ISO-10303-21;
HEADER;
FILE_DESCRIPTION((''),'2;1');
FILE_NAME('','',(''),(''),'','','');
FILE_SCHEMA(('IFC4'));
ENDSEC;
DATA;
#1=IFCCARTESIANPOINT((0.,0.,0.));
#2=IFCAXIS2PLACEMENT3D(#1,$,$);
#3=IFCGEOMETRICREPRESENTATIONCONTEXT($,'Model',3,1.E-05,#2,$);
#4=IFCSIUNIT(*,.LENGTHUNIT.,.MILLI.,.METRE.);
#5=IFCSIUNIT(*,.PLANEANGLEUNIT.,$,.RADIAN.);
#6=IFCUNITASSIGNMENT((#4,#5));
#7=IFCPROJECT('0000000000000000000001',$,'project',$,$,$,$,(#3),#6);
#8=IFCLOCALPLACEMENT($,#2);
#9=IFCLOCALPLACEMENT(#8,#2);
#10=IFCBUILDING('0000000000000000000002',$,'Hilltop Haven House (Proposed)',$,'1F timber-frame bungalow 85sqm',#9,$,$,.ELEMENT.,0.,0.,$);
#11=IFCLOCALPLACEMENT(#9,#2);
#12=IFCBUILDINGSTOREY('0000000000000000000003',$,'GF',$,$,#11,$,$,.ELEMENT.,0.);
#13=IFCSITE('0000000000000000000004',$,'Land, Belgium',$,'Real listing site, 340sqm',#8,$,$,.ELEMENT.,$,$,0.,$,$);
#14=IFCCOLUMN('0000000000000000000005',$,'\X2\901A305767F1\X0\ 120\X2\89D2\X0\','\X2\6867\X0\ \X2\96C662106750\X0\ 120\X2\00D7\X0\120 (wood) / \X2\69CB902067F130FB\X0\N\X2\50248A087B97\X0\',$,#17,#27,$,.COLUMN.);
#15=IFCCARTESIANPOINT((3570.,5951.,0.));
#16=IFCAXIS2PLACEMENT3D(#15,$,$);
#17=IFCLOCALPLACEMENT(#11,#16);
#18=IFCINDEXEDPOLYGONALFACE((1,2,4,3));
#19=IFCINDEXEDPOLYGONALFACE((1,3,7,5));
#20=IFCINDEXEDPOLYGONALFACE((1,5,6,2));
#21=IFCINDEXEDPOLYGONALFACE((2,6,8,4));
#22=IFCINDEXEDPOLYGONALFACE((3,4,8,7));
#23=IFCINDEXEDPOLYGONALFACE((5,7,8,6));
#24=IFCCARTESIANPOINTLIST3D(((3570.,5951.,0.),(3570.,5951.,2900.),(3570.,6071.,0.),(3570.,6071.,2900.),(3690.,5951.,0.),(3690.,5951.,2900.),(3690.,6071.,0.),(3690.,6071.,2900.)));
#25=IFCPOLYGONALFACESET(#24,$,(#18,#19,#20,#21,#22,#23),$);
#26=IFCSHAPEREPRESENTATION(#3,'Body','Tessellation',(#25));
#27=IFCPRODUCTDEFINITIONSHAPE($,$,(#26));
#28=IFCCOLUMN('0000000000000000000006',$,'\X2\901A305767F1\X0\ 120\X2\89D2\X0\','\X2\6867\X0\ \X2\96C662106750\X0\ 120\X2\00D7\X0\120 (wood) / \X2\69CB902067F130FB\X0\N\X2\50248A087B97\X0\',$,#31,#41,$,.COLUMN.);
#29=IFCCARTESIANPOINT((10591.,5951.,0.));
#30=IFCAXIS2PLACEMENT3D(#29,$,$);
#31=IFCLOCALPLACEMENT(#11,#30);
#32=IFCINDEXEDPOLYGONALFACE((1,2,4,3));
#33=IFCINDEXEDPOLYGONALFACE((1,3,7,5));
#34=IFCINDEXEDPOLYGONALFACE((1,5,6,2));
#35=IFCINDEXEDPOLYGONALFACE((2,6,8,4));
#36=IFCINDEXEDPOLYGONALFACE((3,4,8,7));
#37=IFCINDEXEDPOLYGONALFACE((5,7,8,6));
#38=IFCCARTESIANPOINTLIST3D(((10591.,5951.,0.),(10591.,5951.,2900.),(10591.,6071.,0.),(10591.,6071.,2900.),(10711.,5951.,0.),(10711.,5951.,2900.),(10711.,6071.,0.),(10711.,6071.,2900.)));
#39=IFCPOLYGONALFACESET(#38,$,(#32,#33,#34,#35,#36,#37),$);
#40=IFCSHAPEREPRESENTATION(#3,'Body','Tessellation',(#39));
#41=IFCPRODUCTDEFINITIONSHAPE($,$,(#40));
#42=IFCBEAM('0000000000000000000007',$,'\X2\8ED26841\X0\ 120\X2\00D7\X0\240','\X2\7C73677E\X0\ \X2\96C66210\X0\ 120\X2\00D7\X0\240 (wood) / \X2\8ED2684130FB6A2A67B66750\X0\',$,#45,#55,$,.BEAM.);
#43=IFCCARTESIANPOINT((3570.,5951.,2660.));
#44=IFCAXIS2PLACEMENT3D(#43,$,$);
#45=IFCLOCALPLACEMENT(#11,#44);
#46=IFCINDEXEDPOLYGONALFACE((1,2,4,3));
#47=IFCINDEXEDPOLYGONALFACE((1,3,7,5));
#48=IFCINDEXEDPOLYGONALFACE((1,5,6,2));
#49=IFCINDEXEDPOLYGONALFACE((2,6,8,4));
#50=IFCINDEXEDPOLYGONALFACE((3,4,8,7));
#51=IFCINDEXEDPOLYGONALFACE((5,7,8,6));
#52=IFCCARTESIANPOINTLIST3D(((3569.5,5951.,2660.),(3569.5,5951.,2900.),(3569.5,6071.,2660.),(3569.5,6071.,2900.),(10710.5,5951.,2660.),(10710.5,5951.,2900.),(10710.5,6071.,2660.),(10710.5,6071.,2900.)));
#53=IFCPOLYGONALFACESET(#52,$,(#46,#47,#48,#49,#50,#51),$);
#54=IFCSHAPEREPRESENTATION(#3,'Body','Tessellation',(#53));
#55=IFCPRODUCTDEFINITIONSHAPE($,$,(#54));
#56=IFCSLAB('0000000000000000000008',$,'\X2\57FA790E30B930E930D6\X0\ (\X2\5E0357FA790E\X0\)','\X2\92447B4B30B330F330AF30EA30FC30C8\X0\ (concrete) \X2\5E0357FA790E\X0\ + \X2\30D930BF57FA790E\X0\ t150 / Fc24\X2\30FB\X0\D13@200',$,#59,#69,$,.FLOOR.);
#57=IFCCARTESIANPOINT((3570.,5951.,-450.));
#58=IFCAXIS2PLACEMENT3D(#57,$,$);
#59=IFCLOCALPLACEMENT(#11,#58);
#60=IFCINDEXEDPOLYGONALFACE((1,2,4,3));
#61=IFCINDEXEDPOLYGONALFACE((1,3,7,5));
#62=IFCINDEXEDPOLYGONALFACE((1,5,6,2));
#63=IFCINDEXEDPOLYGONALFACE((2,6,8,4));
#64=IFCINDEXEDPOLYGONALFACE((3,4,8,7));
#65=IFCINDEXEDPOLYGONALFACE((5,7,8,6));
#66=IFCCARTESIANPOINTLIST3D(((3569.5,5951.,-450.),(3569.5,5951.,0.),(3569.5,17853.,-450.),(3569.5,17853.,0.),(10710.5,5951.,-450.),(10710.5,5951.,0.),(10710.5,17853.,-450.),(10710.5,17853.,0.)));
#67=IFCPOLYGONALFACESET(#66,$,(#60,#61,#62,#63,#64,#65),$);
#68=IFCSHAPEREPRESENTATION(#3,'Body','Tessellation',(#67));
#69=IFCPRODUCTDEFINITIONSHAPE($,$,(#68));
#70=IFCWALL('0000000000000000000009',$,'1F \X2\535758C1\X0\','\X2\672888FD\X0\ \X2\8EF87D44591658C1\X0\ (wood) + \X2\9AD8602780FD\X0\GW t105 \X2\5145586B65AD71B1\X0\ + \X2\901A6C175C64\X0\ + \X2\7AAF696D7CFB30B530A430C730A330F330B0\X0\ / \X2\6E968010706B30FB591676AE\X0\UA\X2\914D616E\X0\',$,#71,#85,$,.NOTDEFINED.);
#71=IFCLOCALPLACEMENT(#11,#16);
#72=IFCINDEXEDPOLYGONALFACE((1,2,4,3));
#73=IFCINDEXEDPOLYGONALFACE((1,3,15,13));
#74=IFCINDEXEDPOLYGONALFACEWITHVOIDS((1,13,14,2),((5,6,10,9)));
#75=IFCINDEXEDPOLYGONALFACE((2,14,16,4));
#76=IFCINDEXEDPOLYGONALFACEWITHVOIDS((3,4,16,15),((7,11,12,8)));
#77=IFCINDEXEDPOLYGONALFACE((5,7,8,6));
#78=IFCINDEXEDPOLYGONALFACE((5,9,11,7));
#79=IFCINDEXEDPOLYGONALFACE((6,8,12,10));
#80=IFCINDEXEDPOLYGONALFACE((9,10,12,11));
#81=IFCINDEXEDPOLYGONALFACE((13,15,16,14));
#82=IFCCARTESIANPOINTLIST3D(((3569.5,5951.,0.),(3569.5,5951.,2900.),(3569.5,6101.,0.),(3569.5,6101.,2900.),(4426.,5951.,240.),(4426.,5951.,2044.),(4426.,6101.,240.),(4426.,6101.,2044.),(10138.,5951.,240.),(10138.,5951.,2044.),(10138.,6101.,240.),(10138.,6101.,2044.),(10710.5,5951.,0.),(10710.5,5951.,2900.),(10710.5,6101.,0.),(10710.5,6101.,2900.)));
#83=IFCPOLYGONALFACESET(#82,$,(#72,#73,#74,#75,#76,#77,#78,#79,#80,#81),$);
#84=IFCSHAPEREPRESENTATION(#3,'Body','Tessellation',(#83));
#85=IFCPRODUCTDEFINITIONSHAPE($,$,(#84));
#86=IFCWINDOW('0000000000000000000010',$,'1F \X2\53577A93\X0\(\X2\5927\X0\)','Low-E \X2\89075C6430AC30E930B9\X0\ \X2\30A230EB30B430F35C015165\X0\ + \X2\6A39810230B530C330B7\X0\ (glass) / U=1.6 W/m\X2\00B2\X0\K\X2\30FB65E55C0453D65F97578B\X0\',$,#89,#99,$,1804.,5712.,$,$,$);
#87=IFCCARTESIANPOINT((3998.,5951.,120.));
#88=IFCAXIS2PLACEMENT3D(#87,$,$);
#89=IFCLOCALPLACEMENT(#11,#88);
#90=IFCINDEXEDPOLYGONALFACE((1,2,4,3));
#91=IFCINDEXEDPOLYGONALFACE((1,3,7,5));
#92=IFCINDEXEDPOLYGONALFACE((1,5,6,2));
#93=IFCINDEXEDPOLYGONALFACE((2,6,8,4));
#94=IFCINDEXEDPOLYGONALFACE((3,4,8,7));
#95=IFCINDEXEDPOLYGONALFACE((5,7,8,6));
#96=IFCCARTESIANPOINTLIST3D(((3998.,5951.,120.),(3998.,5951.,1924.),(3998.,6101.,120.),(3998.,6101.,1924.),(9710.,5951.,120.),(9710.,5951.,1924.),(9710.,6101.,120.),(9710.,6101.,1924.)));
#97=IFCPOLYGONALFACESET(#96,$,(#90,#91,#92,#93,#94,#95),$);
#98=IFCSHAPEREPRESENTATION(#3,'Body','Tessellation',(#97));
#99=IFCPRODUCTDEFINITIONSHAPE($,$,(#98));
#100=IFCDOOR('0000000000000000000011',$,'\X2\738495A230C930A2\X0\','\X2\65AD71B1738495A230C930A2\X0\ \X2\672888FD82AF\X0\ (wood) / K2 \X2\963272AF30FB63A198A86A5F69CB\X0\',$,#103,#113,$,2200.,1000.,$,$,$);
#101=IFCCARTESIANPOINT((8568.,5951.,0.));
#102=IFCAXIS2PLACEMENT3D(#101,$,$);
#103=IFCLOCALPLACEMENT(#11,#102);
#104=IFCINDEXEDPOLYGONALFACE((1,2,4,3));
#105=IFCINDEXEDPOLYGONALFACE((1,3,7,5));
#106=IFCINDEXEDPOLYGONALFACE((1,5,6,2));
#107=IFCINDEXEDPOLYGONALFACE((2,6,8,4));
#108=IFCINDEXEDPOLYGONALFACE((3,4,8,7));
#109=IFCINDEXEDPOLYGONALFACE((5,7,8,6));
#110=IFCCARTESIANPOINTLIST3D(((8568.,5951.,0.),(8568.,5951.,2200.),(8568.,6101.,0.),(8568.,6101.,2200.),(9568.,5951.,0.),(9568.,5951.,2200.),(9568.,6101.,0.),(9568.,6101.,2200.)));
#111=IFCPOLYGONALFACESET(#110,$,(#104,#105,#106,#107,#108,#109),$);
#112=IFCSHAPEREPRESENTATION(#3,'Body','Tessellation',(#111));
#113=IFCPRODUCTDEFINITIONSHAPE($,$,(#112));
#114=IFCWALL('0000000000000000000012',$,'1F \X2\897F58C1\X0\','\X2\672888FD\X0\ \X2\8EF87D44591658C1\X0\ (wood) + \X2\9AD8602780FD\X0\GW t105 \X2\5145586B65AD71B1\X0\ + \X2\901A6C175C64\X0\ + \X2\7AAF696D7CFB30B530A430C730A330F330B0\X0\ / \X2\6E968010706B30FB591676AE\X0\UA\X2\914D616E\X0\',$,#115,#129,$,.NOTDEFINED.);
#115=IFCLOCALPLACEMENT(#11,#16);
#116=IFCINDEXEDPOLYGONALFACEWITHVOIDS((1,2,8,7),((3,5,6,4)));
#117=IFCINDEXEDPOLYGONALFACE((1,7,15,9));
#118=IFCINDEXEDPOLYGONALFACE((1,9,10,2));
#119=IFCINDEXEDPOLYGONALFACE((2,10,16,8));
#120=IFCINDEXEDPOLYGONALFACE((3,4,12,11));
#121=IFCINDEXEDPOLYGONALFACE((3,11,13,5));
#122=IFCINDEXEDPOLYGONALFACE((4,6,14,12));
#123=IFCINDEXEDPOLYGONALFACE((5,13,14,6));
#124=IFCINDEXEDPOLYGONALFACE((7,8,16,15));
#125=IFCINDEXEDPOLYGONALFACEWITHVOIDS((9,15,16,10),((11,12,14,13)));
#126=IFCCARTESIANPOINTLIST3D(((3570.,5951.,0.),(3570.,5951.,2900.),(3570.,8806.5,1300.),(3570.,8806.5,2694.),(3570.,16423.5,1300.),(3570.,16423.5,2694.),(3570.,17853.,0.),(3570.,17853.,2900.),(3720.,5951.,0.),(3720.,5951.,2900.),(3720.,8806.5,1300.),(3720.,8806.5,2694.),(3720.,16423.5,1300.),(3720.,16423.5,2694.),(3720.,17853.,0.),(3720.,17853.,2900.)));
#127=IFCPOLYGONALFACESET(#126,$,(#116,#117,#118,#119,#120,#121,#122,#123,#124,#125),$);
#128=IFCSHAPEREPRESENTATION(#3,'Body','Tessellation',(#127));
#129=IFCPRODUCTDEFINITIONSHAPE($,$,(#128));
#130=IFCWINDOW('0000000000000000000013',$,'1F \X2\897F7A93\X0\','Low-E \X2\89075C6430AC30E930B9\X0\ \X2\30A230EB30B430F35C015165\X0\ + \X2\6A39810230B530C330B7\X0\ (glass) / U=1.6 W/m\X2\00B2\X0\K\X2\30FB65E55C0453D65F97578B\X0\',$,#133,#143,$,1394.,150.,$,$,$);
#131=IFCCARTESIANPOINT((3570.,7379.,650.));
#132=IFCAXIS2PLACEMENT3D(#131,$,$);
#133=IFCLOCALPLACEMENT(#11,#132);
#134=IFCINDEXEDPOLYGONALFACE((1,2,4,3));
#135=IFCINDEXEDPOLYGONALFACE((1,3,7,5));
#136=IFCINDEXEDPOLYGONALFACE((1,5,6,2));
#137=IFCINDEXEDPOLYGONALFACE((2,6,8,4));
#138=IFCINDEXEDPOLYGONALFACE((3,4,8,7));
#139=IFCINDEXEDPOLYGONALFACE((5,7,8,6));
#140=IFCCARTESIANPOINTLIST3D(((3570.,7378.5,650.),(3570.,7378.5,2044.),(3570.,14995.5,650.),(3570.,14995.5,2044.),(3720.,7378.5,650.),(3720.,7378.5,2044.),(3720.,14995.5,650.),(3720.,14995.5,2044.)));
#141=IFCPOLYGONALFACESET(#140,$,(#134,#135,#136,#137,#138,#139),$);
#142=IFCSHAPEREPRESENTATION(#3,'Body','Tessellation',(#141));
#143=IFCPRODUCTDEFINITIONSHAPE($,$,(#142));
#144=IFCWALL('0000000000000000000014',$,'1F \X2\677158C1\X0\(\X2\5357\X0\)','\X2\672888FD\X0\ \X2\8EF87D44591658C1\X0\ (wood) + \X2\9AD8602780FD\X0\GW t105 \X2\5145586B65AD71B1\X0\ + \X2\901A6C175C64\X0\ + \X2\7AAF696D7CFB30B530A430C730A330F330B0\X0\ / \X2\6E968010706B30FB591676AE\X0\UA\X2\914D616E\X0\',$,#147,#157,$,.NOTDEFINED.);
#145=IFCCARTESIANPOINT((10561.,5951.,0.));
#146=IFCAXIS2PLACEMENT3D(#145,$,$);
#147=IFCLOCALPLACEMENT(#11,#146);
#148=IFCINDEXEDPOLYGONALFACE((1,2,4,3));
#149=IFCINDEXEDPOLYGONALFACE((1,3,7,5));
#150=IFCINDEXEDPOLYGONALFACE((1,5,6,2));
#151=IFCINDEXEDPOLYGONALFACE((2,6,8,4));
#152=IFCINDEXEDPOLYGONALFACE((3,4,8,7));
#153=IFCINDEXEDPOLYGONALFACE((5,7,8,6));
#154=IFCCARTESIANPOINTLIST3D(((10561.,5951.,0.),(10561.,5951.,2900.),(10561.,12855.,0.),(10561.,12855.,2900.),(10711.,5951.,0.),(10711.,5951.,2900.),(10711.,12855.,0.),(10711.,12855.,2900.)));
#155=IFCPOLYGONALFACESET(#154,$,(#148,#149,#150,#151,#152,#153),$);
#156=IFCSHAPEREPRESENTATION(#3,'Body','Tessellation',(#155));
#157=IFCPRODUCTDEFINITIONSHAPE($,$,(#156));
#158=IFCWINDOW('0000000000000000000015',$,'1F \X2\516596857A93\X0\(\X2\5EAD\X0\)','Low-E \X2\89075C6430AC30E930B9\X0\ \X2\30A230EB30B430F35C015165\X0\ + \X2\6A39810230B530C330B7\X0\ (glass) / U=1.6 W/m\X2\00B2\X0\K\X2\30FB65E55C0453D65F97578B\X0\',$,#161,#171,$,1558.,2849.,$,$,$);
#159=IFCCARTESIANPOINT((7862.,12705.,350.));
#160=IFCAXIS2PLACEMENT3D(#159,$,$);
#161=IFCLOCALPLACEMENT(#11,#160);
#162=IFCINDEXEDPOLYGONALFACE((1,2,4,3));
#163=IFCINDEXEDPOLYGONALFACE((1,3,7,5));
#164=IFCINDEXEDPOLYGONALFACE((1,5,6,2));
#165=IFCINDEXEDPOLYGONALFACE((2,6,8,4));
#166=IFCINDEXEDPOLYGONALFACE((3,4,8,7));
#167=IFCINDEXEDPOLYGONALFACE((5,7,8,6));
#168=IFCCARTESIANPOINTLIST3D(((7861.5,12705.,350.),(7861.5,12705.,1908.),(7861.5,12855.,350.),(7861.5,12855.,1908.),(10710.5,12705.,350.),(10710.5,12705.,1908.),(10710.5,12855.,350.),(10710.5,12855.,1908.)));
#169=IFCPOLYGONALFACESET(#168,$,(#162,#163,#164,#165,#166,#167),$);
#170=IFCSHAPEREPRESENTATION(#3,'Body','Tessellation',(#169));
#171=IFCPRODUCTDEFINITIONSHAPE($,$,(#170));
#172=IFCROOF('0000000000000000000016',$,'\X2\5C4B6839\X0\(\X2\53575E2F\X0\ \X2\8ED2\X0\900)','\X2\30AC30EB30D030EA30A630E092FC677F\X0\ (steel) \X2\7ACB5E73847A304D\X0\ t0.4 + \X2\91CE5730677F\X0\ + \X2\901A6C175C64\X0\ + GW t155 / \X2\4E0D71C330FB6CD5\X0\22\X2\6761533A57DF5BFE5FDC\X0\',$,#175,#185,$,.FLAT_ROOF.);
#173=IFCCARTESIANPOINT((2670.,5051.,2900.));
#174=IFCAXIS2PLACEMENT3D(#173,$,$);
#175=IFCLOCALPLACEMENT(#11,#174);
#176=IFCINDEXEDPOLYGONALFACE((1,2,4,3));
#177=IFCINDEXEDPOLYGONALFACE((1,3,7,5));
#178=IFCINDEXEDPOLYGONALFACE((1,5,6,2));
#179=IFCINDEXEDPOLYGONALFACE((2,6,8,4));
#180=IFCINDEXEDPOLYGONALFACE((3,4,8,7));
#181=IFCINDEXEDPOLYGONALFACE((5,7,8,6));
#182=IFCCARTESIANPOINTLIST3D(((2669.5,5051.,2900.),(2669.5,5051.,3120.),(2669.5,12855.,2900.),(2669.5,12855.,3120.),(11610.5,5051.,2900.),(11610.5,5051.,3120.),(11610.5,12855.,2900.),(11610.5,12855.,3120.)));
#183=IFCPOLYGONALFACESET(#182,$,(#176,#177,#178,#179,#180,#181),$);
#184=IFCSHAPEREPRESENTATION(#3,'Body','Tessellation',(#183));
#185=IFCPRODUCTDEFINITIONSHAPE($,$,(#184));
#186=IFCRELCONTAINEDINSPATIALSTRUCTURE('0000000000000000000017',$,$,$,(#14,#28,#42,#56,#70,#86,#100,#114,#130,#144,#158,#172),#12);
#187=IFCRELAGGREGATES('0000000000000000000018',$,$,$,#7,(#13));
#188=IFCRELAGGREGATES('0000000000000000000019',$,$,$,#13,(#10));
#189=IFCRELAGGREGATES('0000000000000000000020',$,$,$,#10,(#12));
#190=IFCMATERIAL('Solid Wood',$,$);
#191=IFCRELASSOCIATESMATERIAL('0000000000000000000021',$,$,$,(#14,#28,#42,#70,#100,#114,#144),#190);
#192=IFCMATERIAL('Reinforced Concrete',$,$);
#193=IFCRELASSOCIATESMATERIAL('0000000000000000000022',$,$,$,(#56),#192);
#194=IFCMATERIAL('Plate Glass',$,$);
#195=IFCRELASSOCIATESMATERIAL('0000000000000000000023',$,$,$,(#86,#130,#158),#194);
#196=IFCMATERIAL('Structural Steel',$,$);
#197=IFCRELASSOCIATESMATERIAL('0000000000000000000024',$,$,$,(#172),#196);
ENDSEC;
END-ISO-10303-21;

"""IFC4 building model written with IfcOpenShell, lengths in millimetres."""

from ifc_helpers import new_model, si_unit, frame, frame_2d, origin, place, context, project, spatial, rectangle, extrude, material, element, fill, save


model = new_model("IFC4")

# Units and contexts
model_context = context("Model", 3, precision=1e-05, world=origin())
ifc_project = project(units=[si_unit("LENGTHUNIT", "METRE", prefix="MILLI"), si_unit("PLANEANGLEUNIT", "RADIAN")], contexts=[model_context])

# Site, building, storey
site_placement = place(None, origin())
site = spatial("IfcSite", under=ifc_project, at=site_placement, Name="Land, Belgium", ObjectType="Real listing site, 340sqm", CompositionType="ELEMENT", RefElevation=0.0)
building_placement = place(site_placement, origin())
building = spatial("IfcBuilding", under=site, at=building_placement, Name="Hilltop Haven House (Proposed)", ObjectType="1F timber-frame bungalow 85sqm", CompositionType="ELEMENT", ElevationOfRefHeight=0.0, ElevationOfTerrain=0.0)
storey_placement = place(building_placement, origin())
storey = spatial("IfcBuildingStorey", under=building, at=storey_placement, Name="GF", CompositionType="ELEMENT", Elevation=0.0)

# Columns
ifc_material_1 = material(Name="Solid Wood")
column_1_placement = place(storey_placement, frame((3570.0, 5951.0, 0.0)))
element("IfcColumn", 1, at=column_1_placement, inside=storey, material=ifc_material_1, Name="通し柱 120角", Description="桧 集成材 120×120 (wood) / 構造柱・N値計算", PredefinedType="COLUMN", context=model_context, shape_type="SweptSolid", body=[
    extrude(rectangle(XDim=120.0, YDim=120.0, at=frame_2d((60.0, 60.0))), frame((3570.0, 5951.0, 0.0)), (0.0, 0.0, 1.0), 2900.0),
])
column_2_placement = place(storey_placement, frame((10591.0, 5951.0, 0.0)))
element("IfcColumn", 2, at=column_2_placement, inside=storey, material=ifc_material_1, Name="通し柱 120角", Description="桧 集成材 120×120 (wood) / 構造柱・N値計算", PredefinedType="COLUMN", context=model_context, shape_type="SweptSolid", body=[
    extrude(rectangle(XDim=120.0, YDim=120.0, at=frame_2d((60.0, 60.0))), frame((10591.0, 5951.0, 0.0)), (0.0, 0.0, 1.0), 2900.0),
])

# Beam
beam_1_placement = place(storey_placement, frame((3570.0, 5951.0, 2660.0)))
element("IfcBeam", 3, at=beam_1_placement, inside=storey, material=ifc_material_1, Name="軒桁 120×240", Description="米松 集成 120×240 (wood) / 軒桁・横架材", PredefinedType="BEAM", context=model_context, shape_type="SweptSolid", body=[
    extrude(rectangle(XDim=7141.0, YDim=120.0, at=frame_2d((3570.0, 60.0))), frame((3570.0, 5951.0, 2660.0)), (0.0, 0.0, 1.0), 240.0),
])

# Slab
ifc_material_2 = material(Name="Reinforced Concrete")
slab_1_placement = place(storey_placement, frame((3570.0, 5951.0, -450.0)))
element("IfcSlab", 4, at=slab_1_placement, inside=storey, material=ifc_material_2, Name="基礎スラブ (布基礎)", Description="鉄筋コンクリート (concrete) 布基礎 + ベタ基礎 t150 / Fc24・D13@200", PredefinedType="FLOOR", context=model_context, shape_type="SweptSolid", body=[
    extrude(rectangle(XDim=7141.0, YDim=11902.0, at=frame_2d((3570.0, 5951.0))), frame((3570.0, 5951.0, -450.0)), (0.0, 0.0, 1.0), 450.0),
])

# Wall, openings, window, door
wall_1_placement = place(storey_placement, frame((3570.0, 5951.0, 0.0)))
wall_1 = element("IfcWall", 5, at=wall_1_placement, inside=storey, material=ifc_material_1, Name="1F 南壁", Description="木製 軸組外壁 (wood) + 高性能GW t105 充填断熱 + 通気層 + 窯業系サイディング / 準耐火・外皮UA配慮", PredefinedType="NOTDEFINED", context=model_context, shape_type="SweptSolid", body=[
    extrude(rectangle(XDim=7141.0, YDim=150.0, at=frame_2d((3570.0, 75.0))), frame((3570.0, 5951.0, 0.0)), (0.0, 0.0, 1.0), 2900.0),
])
opening_1_placement = place(storey_placement, frame((3998.0, 5951.0, 120.0)))
opening_1 = element("IfcOpeningElement", 6, at=opening_1_placement, cuts=wall_1, PredefinedType="NOTDEFINED", context=model_context, shape_type="SweptSolid", body=[
    extrude(rectangle(XDim=5712.0, YDim=150.0, at=frame_2d((2856.0, 75.0))), frame((3998.0, 5951.0, 120.0)), (0.0, 0.0, 1.0), 1804.0),
])
opening_2_placement = place(storey_placement, frame((8568.0, 5951.0, 0.0)))
opening_2 = element("IfcOpeningElement", 7, at=opening_2_placement, cuts=wall_1, PredefinedType="NOTDEFINED", context=model_context, shape_type="SweptSolid", body=[
    extrude(rectangle(XDim=1000.0, YDim=150.0, at=frame_2d((500.0, 75.0))), frame((8568.0, 5951.0, 0.0)), (0.0, 0.0, 1.0), 2200.0),
])
ifc_material_3 = material(Name="Plate Glass")
window_1_placement = place(storey_placement, frame((3998.0, 5951.0, 120.0)))
window_1 = element("IfcWindow", 8, at=window_1_placement, inside=storey, material=ifc_material_3, Name="1F 南窓(大)", Description="Low-E 複層ガラス アルゴン封入 + 樹脂サッシ (glass) / U=1.6 W/m²K・日射取得型", OverallHeight=1804.0, OverallWidth=5712.0, context=model_context, shape_type="SweptSolid", body=[
    extrude(rectangle(XDim=5712.0, YDim=150.0, at=frame_2d((2856.0, 75.0))), frame((3998.0, 5951.0, 120.0)), (0.0, 0.0, 1.0), 1804.0),
])
fill(opening_1, window_1)
door_1_placement = place(storey_placement, frame((8568.0, 5951.0, 0.0)))
door_1 = element("IfcDoor", 9, at=door_1_placement, inside=storey, material=ifc_material_1, Name="玄関ドア", Description="断熱玄関ドア 木製芯 (wood) / K2 防犯・採風機構", OverallHeight=2200.0, OverallWidth=1000.0, context=model_context, shape_type="SweptSolid", body=[
    extrude(rectangle(XDim=1000.0, YDim=150.0, at=frame_2d((500.0, 75.0))), frame((8568.0, 5951.0, 0.0)), (0.0, 0.0, 1.0), 2200.0),
])
fill(opening_2, door_1)

# Walls, openings, windows
wall_2_placement = place(storey_placement, frame((3570.0, 5951.0, 0.0)))
wall_2 = element("IfcWall", 10, at=wall_2_placement, inside=storey, material=ifc_material_1, Name="1F 西壁", Description="木製 軸組外壁 (wood) + 高性能GW t105 充填断熱 + 通気層 + 窯業系サイディング / 準耐火・外皮UA配慮", PredefinedType="NOTDEFINED", context=model_context, shape_type="SweptSolid", body=[
    extrude(rectangle(XDim=150.0, YDim=11902.0, at=frame_2d((75.0, 5951.0))), frame((3570.0, 5951.0, 0.0)), (0.0, 0.0, 1.0), 2900.0),
])
opening_3_placement = place(storey_placement, frame((3570.0, 7379.0, 650.0)))
opening_3 = element("IfcOpeningElement", 11, at=opening_3_placement, cuts=wall_2, PredefinedType="NOTDEFINED", context=model_context, shape_type="SweptSolid", body=[
    extrude(rectangle(XDim=150.0, YDim=7617.0, at=frame_2d((75.0, 3808.0))), frame((3570.0, 7379.0, 650.0)), (0.0, 0.0, 1.0), 1394.0),
])
window_2_placement = place(storey_placement, frame((3570.0, 7379.0, 650.0)))
window_2 = element("IfcWindow", 12, at=window_2_placement, inside=storey, material=ifc_material_3, Name="1F 西窓", Description="Low-E 複層ガラス アルゴン封入 + 樹脂サッシ (glass) / U=1.6 W/m²K・日射取得型", OverallHeight=1394.0, OverallWidth=150.0, context=model_context, shape_type="SweptSolid", body=[
    extrude(rectangle(XDim=150.0, YDim=7617.0, at=frame_2d((75.0, 3808.0))), frame((3570.0, 7379.0, 650.0)), (0.0, 0.0, 1.0), 1394.0),
])
fill(opening_3, window_2)
wall_3_placement = place(storey_placement, frame((10561.0, 5951.0, 0.0)))
wall_3 = element("IfcWall", 13, at=wall_3_placement, inside=storey, material=ifc_material_1, Name="1F 東壁(南)", Description="木製 軸組外壁 (wood) + 高性能GW t105 充填断熱 + 通気層 + 窯業系サイディング / 準耐火・外皮UA配慮", PredefinedType="NOTDEFINED", context=model_context, shape_type="SweptSolid", body=[
    extrude(rectangle(XDim=150.0, YDim=6904.0, at=frame_2d((75.0, 3452.0))), frame((10561.0, 5951.0, 0.0)), (0.0, 0.0, 1.0), 2900.0),
])
opening_4_placement = place(storey_placement, frame((7862.0, 12705.0, 350.0)))
opening_4 = element("IfcOpeningElement", 14, at=opening_4_placement, cuts=wall_3, PredefinedType="NOTDEFINED", context=model_context, shape_type="SweptSolid", body=[
    extrude(rectangle(XDim=2849.0, YDim=150.0, at=frame_2d((1424.0, 75.0))), frame((7862.0, 12705.0, 350.0)), (0.0, 0.0, 1.0), 1558.0),
])
window_3_placement = place(storey_placement, frame((7862.0, 12705.0, 350.0)))
window_3 = element("IfcWindow", 15, at=window_3_placement, inside=storey, material=ifc_material_3, Name="1F 入隅窓(庭)", Description="Low-E 複層ガラス アルゴン封入 + 樹脂サッシ (glass) / U=1.6 W/m²K・日射取得型", OverallHeight=1558.0, OverallWidth=2849.0, context=model_context, shape_type="SweptSolid", body=[
    extrude(rectangle(XDim=2849.0, YDim=150.0, at=frame_2d((1424.0, 75.0))), frame((7862.0, 12705.0, 350.0)), (0.0, 0.0, 1.0), 1558.0),
])
fill(opening_4, window_3)

# Roof
ifc_material_4 = material(Name="Structural Steel")
roof_placement = place(storey_placement, frame((2670.0, 5051.0, 2900.0)))
element("IfcRoof", 16, at=roof_placement, inside=storey, material=ifc_material_4, Name="屋根(南帯 軒900)", Description="ガルバリウム鋼板 (steel) 立平葺き t0.4 + 野地板 + 通気層 + GW t155 / 不燃・法22条区域対応", PredefinedType="FLAT_ROOF", context=model_context, shape_type="SweptSolid", body=[
    extrude(rectangle(XDim=8941.0, YDim=7804.0, at=frame_2d((4470.0, 3902.0))), frame((2670.0, 5051.0, 2900.0)), (0.0, 0.0, 1.0), 220.0),
])

save(model, "model.ifc")
